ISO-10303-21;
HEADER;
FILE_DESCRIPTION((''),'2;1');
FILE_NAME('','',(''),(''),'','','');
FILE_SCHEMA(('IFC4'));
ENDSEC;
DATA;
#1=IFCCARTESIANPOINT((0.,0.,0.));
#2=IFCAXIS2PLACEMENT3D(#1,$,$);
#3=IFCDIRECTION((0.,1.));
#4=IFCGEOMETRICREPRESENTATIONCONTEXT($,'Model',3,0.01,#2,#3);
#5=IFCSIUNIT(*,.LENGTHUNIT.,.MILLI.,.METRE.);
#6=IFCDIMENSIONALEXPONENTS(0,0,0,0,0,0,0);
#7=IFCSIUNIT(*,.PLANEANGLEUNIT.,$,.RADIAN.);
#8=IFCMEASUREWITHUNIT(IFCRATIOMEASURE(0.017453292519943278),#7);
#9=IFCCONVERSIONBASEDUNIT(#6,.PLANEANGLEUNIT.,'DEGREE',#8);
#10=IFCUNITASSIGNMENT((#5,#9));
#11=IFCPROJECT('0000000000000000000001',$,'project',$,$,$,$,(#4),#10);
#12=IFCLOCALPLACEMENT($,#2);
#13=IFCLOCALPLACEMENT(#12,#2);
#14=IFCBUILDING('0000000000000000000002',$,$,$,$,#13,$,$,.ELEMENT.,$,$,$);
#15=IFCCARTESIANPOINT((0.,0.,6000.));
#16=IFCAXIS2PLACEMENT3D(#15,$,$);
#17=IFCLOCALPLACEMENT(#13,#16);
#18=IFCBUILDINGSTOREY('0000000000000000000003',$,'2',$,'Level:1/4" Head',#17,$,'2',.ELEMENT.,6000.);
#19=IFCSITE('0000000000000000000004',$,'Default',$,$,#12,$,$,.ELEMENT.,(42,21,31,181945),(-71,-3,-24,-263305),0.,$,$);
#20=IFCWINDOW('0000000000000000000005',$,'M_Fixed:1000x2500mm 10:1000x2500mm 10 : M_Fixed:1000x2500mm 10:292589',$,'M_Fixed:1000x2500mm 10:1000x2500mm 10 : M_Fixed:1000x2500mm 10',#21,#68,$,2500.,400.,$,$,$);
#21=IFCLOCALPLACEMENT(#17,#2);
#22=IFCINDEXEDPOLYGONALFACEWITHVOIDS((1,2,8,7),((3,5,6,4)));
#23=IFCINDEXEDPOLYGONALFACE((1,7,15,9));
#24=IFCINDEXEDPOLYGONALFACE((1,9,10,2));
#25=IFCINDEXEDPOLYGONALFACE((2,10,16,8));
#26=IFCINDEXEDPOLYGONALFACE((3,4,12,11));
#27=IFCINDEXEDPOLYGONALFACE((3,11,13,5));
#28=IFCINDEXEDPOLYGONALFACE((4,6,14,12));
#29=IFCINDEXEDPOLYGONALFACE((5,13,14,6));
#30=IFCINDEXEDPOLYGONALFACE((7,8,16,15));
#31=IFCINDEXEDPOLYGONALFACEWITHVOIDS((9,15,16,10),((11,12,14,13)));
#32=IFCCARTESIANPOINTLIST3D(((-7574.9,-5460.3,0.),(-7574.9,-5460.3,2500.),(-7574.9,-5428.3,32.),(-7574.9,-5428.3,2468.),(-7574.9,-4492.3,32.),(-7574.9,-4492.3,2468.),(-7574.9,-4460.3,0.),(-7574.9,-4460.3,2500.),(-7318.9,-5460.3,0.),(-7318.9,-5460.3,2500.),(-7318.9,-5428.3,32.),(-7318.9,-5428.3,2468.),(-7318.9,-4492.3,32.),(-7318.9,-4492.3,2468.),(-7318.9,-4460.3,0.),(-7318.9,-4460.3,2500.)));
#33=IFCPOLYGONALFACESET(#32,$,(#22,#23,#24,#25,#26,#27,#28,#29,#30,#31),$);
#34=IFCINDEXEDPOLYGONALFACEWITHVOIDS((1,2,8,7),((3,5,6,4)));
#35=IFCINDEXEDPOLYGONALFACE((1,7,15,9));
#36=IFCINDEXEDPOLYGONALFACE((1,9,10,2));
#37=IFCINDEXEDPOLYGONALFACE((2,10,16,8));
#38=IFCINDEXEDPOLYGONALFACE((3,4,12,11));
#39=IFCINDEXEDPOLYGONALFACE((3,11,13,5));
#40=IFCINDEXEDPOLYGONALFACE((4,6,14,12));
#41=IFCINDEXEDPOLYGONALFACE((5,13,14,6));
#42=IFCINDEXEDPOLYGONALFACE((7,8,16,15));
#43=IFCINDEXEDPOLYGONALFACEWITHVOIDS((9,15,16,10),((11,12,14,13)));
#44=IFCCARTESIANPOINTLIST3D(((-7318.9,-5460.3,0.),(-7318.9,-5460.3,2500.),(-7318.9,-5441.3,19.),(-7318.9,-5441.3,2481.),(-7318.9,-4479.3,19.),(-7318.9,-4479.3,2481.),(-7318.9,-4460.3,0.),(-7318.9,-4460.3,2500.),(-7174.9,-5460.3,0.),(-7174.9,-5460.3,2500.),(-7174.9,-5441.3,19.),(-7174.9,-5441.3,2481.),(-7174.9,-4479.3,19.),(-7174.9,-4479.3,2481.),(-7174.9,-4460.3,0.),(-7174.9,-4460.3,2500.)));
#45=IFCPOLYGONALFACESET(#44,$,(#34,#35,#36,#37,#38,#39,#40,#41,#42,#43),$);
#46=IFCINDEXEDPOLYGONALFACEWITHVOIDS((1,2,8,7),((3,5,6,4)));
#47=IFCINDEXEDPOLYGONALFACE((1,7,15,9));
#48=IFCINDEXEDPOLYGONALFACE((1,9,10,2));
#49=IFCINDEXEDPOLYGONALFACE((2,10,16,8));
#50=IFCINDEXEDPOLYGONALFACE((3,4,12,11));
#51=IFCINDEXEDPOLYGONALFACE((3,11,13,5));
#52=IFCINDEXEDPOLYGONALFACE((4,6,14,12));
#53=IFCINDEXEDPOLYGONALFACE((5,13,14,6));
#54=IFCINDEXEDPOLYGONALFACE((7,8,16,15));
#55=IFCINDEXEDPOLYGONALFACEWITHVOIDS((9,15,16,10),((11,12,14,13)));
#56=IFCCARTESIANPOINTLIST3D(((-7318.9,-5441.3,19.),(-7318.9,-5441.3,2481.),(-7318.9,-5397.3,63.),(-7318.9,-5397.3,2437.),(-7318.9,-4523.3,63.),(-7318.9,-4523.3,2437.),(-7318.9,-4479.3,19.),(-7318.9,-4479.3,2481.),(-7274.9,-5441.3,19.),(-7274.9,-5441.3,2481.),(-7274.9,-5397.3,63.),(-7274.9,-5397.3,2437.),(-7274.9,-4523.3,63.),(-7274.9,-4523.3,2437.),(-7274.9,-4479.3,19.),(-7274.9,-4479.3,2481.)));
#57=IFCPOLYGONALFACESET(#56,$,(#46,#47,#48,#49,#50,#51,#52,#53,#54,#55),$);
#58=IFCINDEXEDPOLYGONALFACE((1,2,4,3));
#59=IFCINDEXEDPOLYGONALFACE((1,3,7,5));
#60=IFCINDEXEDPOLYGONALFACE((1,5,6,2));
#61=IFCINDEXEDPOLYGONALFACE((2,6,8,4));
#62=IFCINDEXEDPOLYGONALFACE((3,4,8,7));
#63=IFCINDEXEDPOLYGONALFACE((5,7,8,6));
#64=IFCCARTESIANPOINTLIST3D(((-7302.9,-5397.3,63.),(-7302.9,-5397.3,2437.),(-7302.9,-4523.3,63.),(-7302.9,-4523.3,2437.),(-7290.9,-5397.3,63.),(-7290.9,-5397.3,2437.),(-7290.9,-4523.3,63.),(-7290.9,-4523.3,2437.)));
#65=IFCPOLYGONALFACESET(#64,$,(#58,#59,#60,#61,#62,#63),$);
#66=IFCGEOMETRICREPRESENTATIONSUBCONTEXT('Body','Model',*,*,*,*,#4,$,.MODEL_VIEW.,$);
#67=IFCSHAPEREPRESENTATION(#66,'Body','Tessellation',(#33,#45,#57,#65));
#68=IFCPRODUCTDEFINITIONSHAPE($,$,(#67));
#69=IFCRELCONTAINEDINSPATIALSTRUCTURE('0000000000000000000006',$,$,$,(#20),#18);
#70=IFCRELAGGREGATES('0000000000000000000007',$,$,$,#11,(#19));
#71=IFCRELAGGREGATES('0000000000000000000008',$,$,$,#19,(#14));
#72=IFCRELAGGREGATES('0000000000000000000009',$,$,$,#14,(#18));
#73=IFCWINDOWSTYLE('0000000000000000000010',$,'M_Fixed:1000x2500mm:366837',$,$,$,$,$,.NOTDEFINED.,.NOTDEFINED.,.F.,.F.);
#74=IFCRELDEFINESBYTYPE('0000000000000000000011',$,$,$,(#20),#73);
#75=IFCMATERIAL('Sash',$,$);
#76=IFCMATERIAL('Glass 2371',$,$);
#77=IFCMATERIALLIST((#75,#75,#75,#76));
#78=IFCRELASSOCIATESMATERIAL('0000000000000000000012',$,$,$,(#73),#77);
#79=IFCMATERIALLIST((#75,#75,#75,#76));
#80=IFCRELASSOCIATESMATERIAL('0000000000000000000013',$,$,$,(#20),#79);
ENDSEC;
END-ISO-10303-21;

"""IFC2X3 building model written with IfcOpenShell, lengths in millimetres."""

from ifc_helpers import new_model, entity, si_unit, converted_unit, direction, frame, frame_2d, origin, place, context, subcontext, project, spatial, polyline, rectangle, outline, extrude, source, transform, mapped, material, material_list, type_object, type_shapes, element, save


model = new_model("IFC2X3")

# Units and contexts
model_context = context("Model", 3, precision=0.01, world=origin(), true_north=direction((0.0, 1.0)))
body_context = subcontext(model_context, "Body", "Model", "MODEL_VIEW")
ifc_project = project(units=[si_unit("LENGTHUNIT", "METRE", prefix="MILLI"), converted_unit("PLANEANGLEUNIT", "DEGREE", entity("IfcRatioMeasure", 0.017453292519943278), si_unit("PLANEANGLEUNIT", "RADIAN"), dimensions=[0, 0, 0, 0, 0, 0, 0])], contexts=[model_context])

# Site, building, storey
site_placement = place(None, origin())
site = spatial("IfcSite", under=ifc_project, at=site_placement, Name="Default", CompositionType="ELEMENT", RefLatitude=(42, 21, 31, 181945), RefLongitude=(-71, -3, -24, -263305), RefElevation=0.0)
building_placement = place(site_placement, origin())
building = spatial("IfcBuilding", under=site, at=building_placement, CompositionType="ELEMENT")
storey_placement = place(building_placement, frame((0.0, 0.0, 6000.0)))
storey = spatial("IfcBuildingStorey", under=building, at=storey_placement, Name="2", ObjectType="Level:1/4\" Head", LongName="2", CompositionType="ELEMENT", Elevation=6000.0)

# Window
ifc_material_1 = material(Name="Sash")
ifc_material_2 = material(Name="Glass 2371")
ifc_material_list_1 = material_list([ifc_material_1, ifc_material_1, ifc_material_1, ifc_material_2])
ifc_material_list_2 = material_list([ifc_material_1, ifc_material_1, ifc_material_1, ifc_material_2])
window_style_1 = type_object("IfcWindowStyle", Name="M_Fixed:1000x2500mm:366837", ConstructionType="NOTDEFINED", OperationType="NOTDEFINED", ParameterTakesPrecedence=False, Sizeable=False, material=ifc_material_list_2)
shared_shape_1 = source(origin(), body_context, "Body", "SweptSolid", [
    extrude(outline(polyline([(-1250.0, -500.0), (1250.0, -500.0), (1250.0, 500.0), (-1250.0, 500.0), (-1250.0, -500.0)]), holes=[polyline([(1218.0, 468.0), (1218.0, -468.0), (-1218.0, -468.0), (-1218.0, 468.0), (1218.0, 468.0)])]), frame((-7574.9, -4960.3, 7250.0), z_axis=(1.0, 0.0, 0.0), x_axis=(0.0, 0.0, -1.0)), (0.0, 0.0, 1.0), 256.0),
    extrude(outline(polyline([(-1250.0, -500.0), (1250.0, -500.0), (1250.0, 500.0), (-1250.0, 500.0), (-1250.0, -500.0)]), holes=[polyline([(1231.0, 481.0), (1231.0, -481.0), (-1231.0, -481.0), (-1231.0, 481.0), (1231.0, 481.0)])]), frame((-7318.9, -4960.3, 7250.0), z_axis=(1.0, 0.0, 0.0), x_axis=(0.0, 0.0, -1.0)), (0.0, 0.0, 1.0), 144.0),
    extrude(outline(polyline([(-1231.0, -481.0), (1231.0, -481.0), (1231.0, 481.0), (-1231.0, 481.0), (-1231.0, -481.0)]), holes=[polyline([(1187.0, 437.0), (1187.0, -437.0), (-1187.0, -437.0), (-1187.0, 437.0), (1187.0, 437.0)])]), frame((-7318.9, -4960.3, 7250.0), z_axis=(1.0, 0.0, 0.0), x_axis=(0.0, 0.0, -1.0)), (0.0, 0.0, 1.0), 44.0),
    extrude(rectangle(XDim=874.0, YDim=12.0, at=frame_2d((0.0, 0.0), x_axis=(1.0, 0.0))), frame((-7296.9, -4960.3, 6063.0), z_axis=(0.0, 0.0, 1.0), x_axis=(0.0, -1.0, 0.0)), (0.0, 0.0, 1.0), 2374.0),
])
type_shapes(window_style_1, [shared_shape_1])
window_1_placement = place(storey_placement, frame((0.0, 0.0, -6000.0)))
element("IfcWindow", 1, at=window_1_placement, inside=storey, type_object=window_style_1, material=ifc_material_list_1, Name="M_Fixed:1000x2500mm 10:1000x2500mm 10 : M_Fixed:1000x2500mm 10:292589", ObjectType="M_Fixed:1000x2500mm 10:1000x2500mm 10 : M_Fixed:1000x2500mm 10", OverallHeight=2500.0, OverallWidth=400.0, context=body_context, shape_type="MappedRepresentation", body=[
    mapped(shared_shape_1, transform((0.0, 0.0, 0.0), scale=1.0)),
])

save(model, "model.ifc")
